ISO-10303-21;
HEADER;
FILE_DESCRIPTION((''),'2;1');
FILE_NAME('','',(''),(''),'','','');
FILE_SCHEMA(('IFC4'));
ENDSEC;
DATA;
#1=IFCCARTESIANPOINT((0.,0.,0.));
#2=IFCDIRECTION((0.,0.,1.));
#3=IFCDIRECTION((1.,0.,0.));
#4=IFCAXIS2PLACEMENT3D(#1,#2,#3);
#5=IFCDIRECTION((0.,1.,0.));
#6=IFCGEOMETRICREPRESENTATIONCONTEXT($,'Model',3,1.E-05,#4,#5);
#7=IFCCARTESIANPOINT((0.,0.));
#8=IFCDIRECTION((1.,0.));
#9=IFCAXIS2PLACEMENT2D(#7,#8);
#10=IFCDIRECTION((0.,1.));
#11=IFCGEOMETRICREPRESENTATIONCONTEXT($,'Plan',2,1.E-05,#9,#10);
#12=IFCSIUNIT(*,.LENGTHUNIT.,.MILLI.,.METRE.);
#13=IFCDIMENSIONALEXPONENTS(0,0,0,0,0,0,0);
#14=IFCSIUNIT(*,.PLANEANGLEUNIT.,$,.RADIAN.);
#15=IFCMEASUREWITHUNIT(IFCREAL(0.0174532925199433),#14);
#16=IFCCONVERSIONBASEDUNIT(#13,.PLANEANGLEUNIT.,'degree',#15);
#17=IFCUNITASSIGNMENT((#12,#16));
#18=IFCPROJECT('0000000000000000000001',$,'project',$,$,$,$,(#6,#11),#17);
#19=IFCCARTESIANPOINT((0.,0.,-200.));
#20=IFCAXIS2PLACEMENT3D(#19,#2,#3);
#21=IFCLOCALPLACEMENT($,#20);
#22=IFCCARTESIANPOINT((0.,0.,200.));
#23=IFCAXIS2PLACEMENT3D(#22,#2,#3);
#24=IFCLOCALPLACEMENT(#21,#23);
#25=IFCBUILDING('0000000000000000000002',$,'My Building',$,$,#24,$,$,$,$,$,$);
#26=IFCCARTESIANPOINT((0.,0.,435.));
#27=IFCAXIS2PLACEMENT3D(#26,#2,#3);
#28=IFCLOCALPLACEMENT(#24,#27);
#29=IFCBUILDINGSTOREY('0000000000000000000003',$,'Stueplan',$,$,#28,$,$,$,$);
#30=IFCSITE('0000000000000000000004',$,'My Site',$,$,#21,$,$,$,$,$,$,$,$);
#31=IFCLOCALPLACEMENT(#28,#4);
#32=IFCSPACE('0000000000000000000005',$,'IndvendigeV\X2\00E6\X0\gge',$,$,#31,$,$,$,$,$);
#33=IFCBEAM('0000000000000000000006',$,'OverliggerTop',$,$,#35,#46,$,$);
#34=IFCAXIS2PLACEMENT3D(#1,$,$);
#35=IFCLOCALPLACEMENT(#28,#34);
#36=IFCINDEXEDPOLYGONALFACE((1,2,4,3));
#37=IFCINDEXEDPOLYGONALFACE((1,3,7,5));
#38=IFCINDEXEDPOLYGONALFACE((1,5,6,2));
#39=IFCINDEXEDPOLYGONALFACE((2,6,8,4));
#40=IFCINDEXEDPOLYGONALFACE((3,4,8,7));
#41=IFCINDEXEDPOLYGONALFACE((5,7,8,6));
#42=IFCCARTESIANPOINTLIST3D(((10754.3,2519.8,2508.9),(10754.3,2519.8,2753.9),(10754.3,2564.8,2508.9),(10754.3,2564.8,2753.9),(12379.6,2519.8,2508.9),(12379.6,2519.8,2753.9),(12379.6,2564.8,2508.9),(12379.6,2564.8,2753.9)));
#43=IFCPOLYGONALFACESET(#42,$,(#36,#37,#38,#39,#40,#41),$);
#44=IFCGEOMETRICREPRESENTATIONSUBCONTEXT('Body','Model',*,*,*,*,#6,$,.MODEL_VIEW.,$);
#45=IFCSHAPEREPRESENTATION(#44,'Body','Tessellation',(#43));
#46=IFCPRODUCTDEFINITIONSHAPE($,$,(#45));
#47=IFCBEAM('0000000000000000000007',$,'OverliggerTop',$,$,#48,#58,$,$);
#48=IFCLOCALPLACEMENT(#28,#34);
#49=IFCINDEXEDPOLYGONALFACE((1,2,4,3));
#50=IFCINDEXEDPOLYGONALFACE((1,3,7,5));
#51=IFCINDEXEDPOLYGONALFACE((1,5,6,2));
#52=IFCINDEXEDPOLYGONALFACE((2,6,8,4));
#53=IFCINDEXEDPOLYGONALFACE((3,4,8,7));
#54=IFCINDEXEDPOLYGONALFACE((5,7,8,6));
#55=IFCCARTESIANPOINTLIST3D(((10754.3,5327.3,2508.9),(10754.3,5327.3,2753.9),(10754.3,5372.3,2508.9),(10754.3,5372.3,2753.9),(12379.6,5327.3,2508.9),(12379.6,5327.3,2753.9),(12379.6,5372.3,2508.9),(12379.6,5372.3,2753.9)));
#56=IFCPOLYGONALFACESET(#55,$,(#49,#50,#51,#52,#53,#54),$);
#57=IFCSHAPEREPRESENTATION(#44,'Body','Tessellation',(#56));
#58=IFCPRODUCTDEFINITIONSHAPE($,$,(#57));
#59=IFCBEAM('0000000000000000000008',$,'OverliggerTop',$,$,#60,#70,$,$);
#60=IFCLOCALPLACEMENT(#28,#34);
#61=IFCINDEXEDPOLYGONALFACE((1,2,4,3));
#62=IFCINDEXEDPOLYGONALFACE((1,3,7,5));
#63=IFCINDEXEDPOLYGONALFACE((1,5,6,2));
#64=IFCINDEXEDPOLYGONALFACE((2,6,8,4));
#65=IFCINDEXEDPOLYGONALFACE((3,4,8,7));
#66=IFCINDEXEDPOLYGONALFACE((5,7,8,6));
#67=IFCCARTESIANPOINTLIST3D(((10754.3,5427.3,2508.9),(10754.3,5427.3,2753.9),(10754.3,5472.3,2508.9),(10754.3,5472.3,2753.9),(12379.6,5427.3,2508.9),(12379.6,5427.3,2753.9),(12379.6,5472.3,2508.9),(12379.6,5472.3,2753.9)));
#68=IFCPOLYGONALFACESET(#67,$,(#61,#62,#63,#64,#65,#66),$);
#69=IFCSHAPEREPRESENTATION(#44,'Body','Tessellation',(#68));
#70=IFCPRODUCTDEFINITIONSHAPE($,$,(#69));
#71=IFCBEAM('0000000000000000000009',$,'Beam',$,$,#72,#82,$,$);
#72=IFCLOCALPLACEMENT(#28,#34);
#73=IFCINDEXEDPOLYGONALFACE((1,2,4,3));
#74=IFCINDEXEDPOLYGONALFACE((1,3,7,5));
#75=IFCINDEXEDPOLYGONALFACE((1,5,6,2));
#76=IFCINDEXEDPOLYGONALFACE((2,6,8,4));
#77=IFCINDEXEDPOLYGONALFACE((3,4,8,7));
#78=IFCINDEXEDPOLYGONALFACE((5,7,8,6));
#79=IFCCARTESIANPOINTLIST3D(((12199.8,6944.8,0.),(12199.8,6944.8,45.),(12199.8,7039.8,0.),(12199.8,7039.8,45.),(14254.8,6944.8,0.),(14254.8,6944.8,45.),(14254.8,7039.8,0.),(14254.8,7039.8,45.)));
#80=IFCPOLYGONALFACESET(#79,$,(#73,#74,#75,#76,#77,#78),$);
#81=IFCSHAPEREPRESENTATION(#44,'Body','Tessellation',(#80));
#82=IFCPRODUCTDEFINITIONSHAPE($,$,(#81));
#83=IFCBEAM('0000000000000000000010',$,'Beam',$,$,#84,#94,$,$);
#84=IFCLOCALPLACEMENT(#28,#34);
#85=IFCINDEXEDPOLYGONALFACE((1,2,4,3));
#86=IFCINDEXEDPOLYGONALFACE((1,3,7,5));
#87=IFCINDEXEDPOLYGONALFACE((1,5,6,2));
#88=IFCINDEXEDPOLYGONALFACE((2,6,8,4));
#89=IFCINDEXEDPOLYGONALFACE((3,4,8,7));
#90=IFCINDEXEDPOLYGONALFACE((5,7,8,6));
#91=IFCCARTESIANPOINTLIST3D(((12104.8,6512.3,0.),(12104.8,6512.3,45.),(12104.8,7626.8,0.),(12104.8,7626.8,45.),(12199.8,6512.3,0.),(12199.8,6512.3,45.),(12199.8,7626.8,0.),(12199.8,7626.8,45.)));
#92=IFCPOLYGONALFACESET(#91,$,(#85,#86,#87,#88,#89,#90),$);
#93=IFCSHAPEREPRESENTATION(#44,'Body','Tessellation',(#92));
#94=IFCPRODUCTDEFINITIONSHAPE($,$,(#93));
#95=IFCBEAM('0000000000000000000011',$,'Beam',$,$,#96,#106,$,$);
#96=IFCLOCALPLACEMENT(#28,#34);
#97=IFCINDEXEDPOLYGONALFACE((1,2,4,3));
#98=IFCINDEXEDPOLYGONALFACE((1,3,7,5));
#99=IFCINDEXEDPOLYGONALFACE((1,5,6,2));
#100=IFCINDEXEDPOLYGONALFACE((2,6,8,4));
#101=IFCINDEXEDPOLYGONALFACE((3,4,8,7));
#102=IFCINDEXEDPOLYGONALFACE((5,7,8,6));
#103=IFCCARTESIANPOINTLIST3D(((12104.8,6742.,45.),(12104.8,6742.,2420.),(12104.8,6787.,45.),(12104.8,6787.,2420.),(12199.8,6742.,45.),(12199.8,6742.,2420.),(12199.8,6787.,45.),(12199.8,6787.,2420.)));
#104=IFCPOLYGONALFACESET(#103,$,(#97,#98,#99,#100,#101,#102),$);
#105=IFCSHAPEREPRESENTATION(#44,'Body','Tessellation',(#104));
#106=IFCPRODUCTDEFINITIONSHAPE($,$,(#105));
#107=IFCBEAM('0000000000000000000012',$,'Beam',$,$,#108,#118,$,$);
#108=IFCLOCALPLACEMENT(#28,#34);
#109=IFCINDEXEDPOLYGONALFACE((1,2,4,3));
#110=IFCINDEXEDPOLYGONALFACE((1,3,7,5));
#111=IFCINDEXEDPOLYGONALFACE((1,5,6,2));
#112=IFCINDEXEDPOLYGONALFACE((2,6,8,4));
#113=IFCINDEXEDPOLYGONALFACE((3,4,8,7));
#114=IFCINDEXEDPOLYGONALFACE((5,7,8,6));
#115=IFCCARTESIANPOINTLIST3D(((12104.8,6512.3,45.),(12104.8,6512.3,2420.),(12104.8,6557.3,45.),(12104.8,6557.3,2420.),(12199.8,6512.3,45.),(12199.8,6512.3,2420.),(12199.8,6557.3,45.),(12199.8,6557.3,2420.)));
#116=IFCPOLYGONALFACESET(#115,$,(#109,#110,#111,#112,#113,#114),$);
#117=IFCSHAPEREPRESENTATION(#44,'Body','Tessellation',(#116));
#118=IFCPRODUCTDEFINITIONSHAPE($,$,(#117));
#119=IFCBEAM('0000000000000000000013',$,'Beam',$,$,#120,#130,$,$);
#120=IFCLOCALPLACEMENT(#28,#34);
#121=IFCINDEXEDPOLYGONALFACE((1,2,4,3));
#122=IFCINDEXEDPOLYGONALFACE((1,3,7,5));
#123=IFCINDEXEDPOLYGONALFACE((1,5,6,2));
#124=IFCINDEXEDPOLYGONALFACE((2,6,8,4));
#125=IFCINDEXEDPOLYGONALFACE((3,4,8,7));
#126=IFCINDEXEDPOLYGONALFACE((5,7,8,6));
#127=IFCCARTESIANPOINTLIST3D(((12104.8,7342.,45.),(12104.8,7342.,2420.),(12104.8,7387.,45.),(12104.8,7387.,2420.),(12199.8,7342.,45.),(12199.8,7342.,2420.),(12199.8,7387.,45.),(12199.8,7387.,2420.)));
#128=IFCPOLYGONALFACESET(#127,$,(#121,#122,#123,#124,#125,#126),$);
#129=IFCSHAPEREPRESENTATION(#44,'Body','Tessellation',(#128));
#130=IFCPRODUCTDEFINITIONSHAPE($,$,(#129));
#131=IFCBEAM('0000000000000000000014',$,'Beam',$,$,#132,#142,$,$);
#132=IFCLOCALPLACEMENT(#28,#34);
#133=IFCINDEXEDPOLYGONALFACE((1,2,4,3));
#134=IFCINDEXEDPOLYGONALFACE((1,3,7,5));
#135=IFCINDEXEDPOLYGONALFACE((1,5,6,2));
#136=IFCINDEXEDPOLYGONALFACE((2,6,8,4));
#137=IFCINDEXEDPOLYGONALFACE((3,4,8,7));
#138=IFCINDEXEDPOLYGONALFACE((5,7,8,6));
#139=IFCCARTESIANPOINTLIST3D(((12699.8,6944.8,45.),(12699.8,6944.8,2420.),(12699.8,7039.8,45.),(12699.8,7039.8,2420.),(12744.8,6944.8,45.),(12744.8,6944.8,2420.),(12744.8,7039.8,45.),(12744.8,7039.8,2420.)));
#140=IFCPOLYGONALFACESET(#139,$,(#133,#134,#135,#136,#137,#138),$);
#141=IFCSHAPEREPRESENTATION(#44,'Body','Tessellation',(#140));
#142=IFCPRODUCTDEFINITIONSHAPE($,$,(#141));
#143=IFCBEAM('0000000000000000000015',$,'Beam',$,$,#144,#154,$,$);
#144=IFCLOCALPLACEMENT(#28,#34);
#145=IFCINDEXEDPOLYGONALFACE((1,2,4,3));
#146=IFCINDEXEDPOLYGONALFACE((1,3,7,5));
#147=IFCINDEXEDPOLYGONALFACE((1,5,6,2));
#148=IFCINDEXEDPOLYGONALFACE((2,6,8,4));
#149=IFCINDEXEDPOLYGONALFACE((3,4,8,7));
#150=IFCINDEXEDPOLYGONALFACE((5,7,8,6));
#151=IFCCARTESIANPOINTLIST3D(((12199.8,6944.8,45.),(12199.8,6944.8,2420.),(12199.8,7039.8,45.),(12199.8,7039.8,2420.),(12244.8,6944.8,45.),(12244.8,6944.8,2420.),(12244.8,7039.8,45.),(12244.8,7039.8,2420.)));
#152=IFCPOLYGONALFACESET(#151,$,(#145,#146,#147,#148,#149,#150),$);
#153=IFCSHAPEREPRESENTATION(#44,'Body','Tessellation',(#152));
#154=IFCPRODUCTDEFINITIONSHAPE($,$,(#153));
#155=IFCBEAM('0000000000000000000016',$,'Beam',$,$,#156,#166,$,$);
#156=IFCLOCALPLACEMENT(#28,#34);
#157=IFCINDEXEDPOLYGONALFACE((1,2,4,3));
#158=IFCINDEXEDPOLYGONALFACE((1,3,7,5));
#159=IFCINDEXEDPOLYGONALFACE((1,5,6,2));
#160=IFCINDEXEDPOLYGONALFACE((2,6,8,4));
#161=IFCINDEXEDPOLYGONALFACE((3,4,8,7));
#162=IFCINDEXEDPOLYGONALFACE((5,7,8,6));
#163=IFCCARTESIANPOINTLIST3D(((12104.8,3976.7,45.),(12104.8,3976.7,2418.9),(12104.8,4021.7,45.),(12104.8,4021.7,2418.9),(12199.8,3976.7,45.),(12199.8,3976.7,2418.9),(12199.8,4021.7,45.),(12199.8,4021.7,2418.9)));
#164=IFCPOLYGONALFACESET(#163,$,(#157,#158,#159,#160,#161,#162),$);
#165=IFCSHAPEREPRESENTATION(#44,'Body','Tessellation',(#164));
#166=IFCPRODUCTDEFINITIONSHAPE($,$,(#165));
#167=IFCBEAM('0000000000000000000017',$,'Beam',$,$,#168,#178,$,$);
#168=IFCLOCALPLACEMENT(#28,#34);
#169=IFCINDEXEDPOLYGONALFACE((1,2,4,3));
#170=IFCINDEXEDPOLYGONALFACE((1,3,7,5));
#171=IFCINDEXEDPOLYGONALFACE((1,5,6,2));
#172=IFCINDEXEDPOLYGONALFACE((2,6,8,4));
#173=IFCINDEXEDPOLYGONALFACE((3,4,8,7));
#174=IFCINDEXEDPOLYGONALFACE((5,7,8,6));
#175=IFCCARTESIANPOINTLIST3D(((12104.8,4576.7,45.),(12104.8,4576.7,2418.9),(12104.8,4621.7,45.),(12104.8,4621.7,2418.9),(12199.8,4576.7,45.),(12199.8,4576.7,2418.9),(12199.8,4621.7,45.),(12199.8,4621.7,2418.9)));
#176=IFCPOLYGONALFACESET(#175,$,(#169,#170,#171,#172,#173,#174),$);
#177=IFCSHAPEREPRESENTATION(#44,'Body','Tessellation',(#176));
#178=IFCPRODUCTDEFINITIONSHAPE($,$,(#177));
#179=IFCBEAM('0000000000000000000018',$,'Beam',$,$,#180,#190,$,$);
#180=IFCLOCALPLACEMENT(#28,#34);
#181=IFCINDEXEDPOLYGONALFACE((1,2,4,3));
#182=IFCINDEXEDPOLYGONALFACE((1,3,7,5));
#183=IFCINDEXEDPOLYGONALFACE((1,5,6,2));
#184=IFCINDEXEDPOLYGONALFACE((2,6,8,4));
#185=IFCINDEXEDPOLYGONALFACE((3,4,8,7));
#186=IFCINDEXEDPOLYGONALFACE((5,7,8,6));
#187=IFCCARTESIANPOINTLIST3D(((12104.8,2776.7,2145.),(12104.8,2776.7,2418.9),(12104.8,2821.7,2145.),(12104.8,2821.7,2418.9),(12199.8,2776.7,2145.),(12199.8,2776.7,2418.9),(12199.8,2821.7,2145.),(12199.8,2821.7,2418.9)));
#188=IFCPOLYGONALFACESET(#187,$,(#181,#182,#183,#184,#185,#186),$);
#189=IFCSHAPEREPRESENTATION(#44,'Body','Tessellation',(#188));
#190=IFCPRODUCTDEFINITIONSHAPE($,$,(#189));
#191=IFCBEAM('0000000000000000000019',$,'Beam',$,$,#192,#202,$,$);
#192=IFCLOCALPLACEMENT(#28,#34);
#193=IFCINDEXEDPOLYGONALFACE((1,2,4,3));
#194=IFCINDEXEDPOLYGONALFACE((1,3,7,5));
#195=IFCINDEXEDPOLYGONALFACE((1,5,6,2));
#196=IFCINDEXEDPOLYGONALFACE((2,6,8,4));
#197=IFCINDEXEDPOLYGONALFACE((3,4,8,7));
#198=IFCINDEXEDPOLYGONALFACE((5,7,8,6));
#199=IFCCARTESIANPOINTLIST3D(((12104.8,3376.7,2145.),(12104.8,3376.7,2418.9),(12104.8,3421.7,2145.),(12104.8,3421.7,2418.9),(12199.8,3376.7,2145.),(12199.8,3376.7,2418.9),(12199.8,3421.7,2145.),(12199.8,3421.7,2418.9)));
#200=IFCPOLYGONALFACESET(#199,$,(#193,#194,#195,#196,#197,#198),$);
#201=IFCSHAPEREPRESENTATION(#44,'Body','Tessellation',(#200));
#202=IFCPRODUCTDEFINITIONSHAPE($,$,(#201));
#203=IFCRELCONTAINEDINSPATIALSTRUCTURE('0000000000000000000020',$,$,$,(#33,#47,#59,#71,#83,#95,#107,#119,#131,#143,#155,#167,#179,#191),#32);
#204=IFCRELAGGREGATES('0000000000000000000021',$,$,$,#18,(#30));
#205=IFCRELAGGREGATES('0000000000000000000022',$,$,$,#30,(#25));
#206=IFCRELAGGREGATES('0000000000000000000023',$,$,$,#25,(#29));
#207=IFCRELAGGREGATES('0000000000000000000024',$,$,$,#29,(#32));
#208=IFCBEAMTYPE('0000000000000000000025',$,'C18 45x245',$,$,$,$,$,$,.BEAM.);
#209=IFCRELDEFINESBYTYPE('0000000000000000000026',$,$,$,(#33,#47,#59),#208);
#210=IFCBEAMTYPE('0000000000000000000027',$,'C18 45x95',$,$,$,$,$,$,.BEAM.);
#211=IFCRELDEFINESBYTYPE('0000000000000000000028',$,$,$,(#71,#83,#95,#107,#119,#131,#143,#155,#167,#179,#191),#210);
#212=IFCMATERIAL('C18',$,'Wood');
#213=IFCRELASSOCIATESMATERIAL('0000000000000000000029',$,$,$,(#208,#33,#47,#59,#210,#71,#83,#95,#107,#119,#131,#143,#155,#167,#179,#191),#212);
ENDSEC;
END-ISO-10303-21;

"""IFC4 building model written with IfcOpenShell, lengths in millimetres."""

from ifc_helpers import new_model, entity, si_unit, converted_unit, direction, frame, origin_with_axes, origin_2d_with_axis, place, context, subcontext, project, spatial, rectangle, extrude, material, material_profile, profile_set, profile_usage, type_object, element, save


model = new_model("IFC4")

# Units and contexts
model_context = context("Model", 3, precision=1e-05, world=origin_with_axes(), true_north=direction((0.0, 1.0, 0.0)))
plan_context = context("Plan", 2, precision=1e-05, world=origin_2d_with_axis(), true_north=direction((0.0, 1.0)))
body_context_1 = subcontext(model_context, "Body", "Model", "MODEL_VIEW")
ifc_project = project(units=[si_unit("LENGTHUNIT", "METRE", prefix="MILLI"), converted_unit("PLANEANGLEUNIT", "degree", entity("IfcReal", 0.0174532925199433), si_unit("PLANEANGLEUNIT", "RADIAN"), dimensions=[0, 0, 0, 0, 0, 0, 0])], contexts=[model_context, plan_context])

# Site, building, storey, space
site_placement = place(None, frame((0.0, 0.0, -200.0), z_axis=(0.0, 0.0, 1.0), x_axis=(1.0, 0.0, 0.0)))
site = spatial("IfcSite", under=ifc_project, at=site_placement, Name="My Site")
building_placement = place(site_placement, frame((0.0, 0.0, 200.0), z_axis=(0.0, 0.0, 1.0), x_axis=(1.0, 0.0, 0.0)))
building = spatial("IfcBuilding", under=site, at=building_placement, Name="My Building")
storey_placement = place(building_placement, frame((0.0, 0.0, 435.0), z_axis=(0.0, 0.0, 1.0), x_axis=(1.0, 0.0, 0.0)))
storey = spatial("IfcBuildingStorey", under=building, at=storey_placement, Name="Stueplan")
space_1_placement = place(storey_placement, frame((0.0, 0.0, 0.0), z_axis=(0.0, 0.0, 1.0), x_axis=(1.0, 0.0, 0.0)))
space_1 = spatial("IfcSpace", under=storey, at=space_1_placement, Name="IndvendigeVægge")

# Beams
ifc_material = material(Name="C18", Category="Wood")
ifc_material_profile_1 = material_profile(ifc_material, rectangle(XDim=45.0, YDim=245.0), Name="concrete")
ifc_profile_set_1 = profile_set([ifc_material_profile_1], Name="woodStructural")
ifc_profile_usage_1 = profile_usage(ifc_profile_set_1)
beam_type_1 = type_object("IfcBeamType", Name="C18 45x245", PredefinedType="BEAM", material=ifc_profile_set_1)
beam_1_placement = place(space_1_placement, frame((12379.6, 2542.3, 2631.4), z_axis=(-1.0, 0.0, 0.0), x_axis=(0.0, 1.0, 0.0)))
element("IfcBeam", 1, at=beam_1_placement, inside=space_1, type_object=beam_type_1, material=ifc_profile_usage_1, Name="OverliggerTop", context=body_context_1, shape_type="SweptSolid", body=[
    extrude(rectangle(XDim=45.0, YDim=245.0), origin_with_axes(), (0.0, 0.0, 1.0), 1625.3),
])
ifc_profile_usage_2 = profile_usage(ifc_profile_set_1)
beam_2_placement = place(space_1_placement, frame((12379.6, 5349.8, 2631.4), z_axis=(-1.0, 0.0, 0.0), x_axis=(0.0, 1.0, 0.0)))
element("IfcBeam", 2, at=beam_2_placement, inside=space_1, type_object=beam_type_1, material=ifc_profile_usage_2, Name="OverliggerTop", context=body_context_1, shape_type="SweptSolid", body=[
    extrude(rectangle(XDim=45.0, YDim=245.0), origin_with_axes(), (0.0, 0.0, 1.0), 1625.3),
])
ifc_profile_usage_3 = profile_usage(ifc_profile_set_1)
beam_3_placement = place(space_1_placement, frame((12379.6, 5449.8, 2631.4), z_axis=(-1.0, 0.0, 0.0), x_axis=(0.0, 1.0, 0.0)))
element("IfcBeam", 3, at=beam_3_placement, inside=space_1, type_object=beam_type_1, material=ifc_profile_usage_3, Name="OverliggerTop", context=body_context_1, shape_type="SweptSolid", body=[
    extrude(rectangle(XDim=45.0, YDim=245.0), origin_with_axes(), (0.0, 0.0, 1.0), 1625.3),
])
ifc_material_profile_2 = material_profile(ifc_material, rectangle(XDim=45.0, YDim=95.0))
ifc_profile_set_2 = profile_set([ifc_material_profile_2], Name="woodStructural")
ifc_profile_usage_4 = profile_usage(ifc_profile_set_2, cardinal=5)
beam_type_2 = type_object("IfcBeamType", Name="C18 45x95", PredefinedType="BEAM", material=ifc_profile_set_2)
beam_4_placement = place(space_1_placement, frame((12199.8, 6992.3, 22.5), z_axis=(1.0, 0.0, 0.0), x_axis=(0.0, 0.0, 1.0)))
element("IfcBeam", 4, at=beam_4_placement, inside=space_1, type_object=beam_type_2, material=ifc_profile_usage_4, Name="Beam", context=body_context_1, shape_type="SweptSolid", body=[
    extrude(rectangle(XDim=45.0, YDim=95.0), origin_with_axes(), (0.0, 0.0, 1.0), 2055.0),
])
ifc_profile_usage_5 = profile_usage(ifc_profile_set_2, cardinal=5)
beam_5_placement = place(space_1_placement, frame((12152.3, 6512.3, 22.5), z_axis=(0.0, 1.0, 0.0), x_axis=(0.0, 0.0, 1.0)))
element("IfcBeam", 5, at=beam_5_placement, inside=space_1, type_object=beam_type_2, material=ifc_profile_usage_5, Name="Beam", context=body_context_1, shape_type="SweptSolid", body=[
    extrude(rectangle(XDim=45.0, YDim=95.0), origin_with_axes(), (0.0, 0.0, 1.0), 1114.5),
])
ifc_profile_usage_6 = profile_usage(ifc_profile_set_2)
beam_6_placement = place(space_1_placement, frame((12152.3, 6764.5, 45.0), z_axis=(0.0, 0.0, 1.0), x_axis=(0.0, 1.0, 0.0)))
element("IfcBeam", 6, at=beam_6_placement, inside=space_1, type_object=beam_type_2, material=ifc_profile_usage_6, Name="Beam", context=body_context_1, shape_type="SweptSolid", body=[
    extrude(rectangle(XDim=45.0, YDim=95.0), origin_with_axes(), (0.0, 0.0, 1.0), 2375.0),
])
ifc_profile_usage_7 = profile_usage(ifc_profile_set_2)
beam_7_placement = place(space_1_placement, frame((12152.3, 6534.8, 45.0), z_axis=(0.0, 0.0, 1.0), x_axis=(0.0, 1.0, 0.0)))
element("IfcBeam", 7, at=beam_7_placement, inside=space_1, type_object=beam_type_2, material=ifc_profile_usage_7, Name="Beam", context=body_context_1, shape_type="SweptSolid", body=[
    extrude(rectangle(XDim=45.0, YDim=95.0), origin_with_axes(), (0.0, 0.0, 1.0), 2375.0),
])
ifc_profile_usage_8 = profile_usage(ifc_profile_set_2)
beam_8_placement = place(space_1_placement, frame((12152.3, 7364.5, 45.0), z_axis=(0.0, 0.0, 1.0), x_axis=(0.0, 1.0, 0.0)))
element("IfcBeam", 8, at=beam_8_placement, inside=space_1, type_object=beam_type_2, material=ifc_profile_usage_8, Name="Beam", context=body_context_1, shape_type="SweptSolid", body=[
    extrude(rectangle(XDim=45.0, YDim=95.0), origin_with_axes(), (0.0, 0.0, 1.0), 2375.0),
])
ifc_profile_usage_9 = profile_usage(ifc_profile_set_2)
beam_9_placement = place(space_1_placement, frame((12722.3, 6992.3, 45.0), z_axis=(0.0, 0.0, 1.0), x_axis=(-1.0, 0.0, 0.0)))
element("IfcBeam", 9, at=beam_9_placement, inside=space_1, type_object=beam_type_2, material=ifc_profile_usage_9, Name="Beam", context=body_context_1, shape_type="SweptSolid", body=[
    extrude(rectangle(XDim=45.0, YDim=95.0), origin_with_axes(), (0.0, 0.0, 1.0), 2375.0),
])
ifc_profile_usage_10 = profile_usage(ifc_profile_set_2)
beam_10_placement = place(space_1_placement, frame((12222.3, 6992.3, 45.0), z_axis=(0.0, 0.0, 1.0), x_axis=(-1.0, 0.0, 0.0)))
element("IfcBeam", 10, at=beam_10_placement, inside=space_1, type_object=beam_type_2, material=ifc_profile_usage_10, Name="Beam", context=body_context_1, shape_type="SweptSolid", body=[
    extrude(rectangle(XDim=45.0, YDim=95.0), origin_with_axes(), (0.0, 0.0, 1.0), 2375.0),
])
ifc_profile_usage_11 = profile_usage(ifc_profile_set_2)
beam_11_placement = place(space_1_placement, frame((12152.3, 3999.2, 45.0), z_axis=(0.0, 0.0, 1.0), x_axis=(0.0, -1.0, 0.0)))
element("IfcBeam", 11, at=beam_11_placement, inside=space_1, type_object=beam_type_2, material=ifc_profile_usage_11, Name="Beam", context=body_context_1, shape_type="SweptSolid", body=[
    extrude(rectangle(XDim=45.0, YDim=95.0), origin_with_axes(), (0.0, 0.0, 1.0), 2373.9),
])
ifc_profile_usage_12 = profile_usage(ifc_profile_set_2)
beam_12_placement = place(space_1_placement, frame((12152.3, 4599.2, 45.0), z_axis=(0.0, 0.0, 1.0), x_axis=(0.0, -1.0, 0.0)))
element("IfcBeam", 12, at=beam_12_placement, inside=space_1, type_object=beam_type_2, material=ifc_profile_usage_12, Name="Beam", context=body_context_1, shape_type="SweptSolid", body=[
    extrude(rectangle(XDim=45.0, YDim=95.0), origin_with_axes(), (0.0, 0.0, 1.0), 2373.9),
])
ifc_profile_usage_13 = profile_usage(ifc_profile_set_2)
beam_13_placement = place(space_1_placement, frame((12152.3, 2799.2, 2145.0), z_axis=(0.0, 0.0, 1.0), x_axis=(0.0, -1.0, 0.0)))
element("IfcBeam", 13, at=beam_13_placement, inside=space_1, type_object=beam_type_2, material=ifc_profile_usage_13, Name="Beam", context=body_context_1, shape_type="SweptSolid", body=[
    extrude(rectangle(XDim=45.0, YDim=95.0), origin_with_axes(), (0.0, 0.0, 1.0), 273.9),
])
ifc_profile_usage_14 = profile_usage(ifc_profile_set_2)
beam_14_placement = place(space_1_placement, frame((12152.3, 3399.2, 2145.0), z_axis=(0.0, 0.0, 1.0), x_axis=(0.0, -1.0, 0.0)))
element("IfcBeam", 14, at=beam_14_placement, inside=space_1, type_object=beam_type_2, material=ifc_profile_usage_14, Name="Beam", context=body_context_1, shape_type="SweptSolid", body=[
    extrude(rectangle(XDim=45.0, YDim=95.0), origin_with_axes(), (0.0, 0.0, 1.0), 273.9),
])

save(model, "model.ifc")
